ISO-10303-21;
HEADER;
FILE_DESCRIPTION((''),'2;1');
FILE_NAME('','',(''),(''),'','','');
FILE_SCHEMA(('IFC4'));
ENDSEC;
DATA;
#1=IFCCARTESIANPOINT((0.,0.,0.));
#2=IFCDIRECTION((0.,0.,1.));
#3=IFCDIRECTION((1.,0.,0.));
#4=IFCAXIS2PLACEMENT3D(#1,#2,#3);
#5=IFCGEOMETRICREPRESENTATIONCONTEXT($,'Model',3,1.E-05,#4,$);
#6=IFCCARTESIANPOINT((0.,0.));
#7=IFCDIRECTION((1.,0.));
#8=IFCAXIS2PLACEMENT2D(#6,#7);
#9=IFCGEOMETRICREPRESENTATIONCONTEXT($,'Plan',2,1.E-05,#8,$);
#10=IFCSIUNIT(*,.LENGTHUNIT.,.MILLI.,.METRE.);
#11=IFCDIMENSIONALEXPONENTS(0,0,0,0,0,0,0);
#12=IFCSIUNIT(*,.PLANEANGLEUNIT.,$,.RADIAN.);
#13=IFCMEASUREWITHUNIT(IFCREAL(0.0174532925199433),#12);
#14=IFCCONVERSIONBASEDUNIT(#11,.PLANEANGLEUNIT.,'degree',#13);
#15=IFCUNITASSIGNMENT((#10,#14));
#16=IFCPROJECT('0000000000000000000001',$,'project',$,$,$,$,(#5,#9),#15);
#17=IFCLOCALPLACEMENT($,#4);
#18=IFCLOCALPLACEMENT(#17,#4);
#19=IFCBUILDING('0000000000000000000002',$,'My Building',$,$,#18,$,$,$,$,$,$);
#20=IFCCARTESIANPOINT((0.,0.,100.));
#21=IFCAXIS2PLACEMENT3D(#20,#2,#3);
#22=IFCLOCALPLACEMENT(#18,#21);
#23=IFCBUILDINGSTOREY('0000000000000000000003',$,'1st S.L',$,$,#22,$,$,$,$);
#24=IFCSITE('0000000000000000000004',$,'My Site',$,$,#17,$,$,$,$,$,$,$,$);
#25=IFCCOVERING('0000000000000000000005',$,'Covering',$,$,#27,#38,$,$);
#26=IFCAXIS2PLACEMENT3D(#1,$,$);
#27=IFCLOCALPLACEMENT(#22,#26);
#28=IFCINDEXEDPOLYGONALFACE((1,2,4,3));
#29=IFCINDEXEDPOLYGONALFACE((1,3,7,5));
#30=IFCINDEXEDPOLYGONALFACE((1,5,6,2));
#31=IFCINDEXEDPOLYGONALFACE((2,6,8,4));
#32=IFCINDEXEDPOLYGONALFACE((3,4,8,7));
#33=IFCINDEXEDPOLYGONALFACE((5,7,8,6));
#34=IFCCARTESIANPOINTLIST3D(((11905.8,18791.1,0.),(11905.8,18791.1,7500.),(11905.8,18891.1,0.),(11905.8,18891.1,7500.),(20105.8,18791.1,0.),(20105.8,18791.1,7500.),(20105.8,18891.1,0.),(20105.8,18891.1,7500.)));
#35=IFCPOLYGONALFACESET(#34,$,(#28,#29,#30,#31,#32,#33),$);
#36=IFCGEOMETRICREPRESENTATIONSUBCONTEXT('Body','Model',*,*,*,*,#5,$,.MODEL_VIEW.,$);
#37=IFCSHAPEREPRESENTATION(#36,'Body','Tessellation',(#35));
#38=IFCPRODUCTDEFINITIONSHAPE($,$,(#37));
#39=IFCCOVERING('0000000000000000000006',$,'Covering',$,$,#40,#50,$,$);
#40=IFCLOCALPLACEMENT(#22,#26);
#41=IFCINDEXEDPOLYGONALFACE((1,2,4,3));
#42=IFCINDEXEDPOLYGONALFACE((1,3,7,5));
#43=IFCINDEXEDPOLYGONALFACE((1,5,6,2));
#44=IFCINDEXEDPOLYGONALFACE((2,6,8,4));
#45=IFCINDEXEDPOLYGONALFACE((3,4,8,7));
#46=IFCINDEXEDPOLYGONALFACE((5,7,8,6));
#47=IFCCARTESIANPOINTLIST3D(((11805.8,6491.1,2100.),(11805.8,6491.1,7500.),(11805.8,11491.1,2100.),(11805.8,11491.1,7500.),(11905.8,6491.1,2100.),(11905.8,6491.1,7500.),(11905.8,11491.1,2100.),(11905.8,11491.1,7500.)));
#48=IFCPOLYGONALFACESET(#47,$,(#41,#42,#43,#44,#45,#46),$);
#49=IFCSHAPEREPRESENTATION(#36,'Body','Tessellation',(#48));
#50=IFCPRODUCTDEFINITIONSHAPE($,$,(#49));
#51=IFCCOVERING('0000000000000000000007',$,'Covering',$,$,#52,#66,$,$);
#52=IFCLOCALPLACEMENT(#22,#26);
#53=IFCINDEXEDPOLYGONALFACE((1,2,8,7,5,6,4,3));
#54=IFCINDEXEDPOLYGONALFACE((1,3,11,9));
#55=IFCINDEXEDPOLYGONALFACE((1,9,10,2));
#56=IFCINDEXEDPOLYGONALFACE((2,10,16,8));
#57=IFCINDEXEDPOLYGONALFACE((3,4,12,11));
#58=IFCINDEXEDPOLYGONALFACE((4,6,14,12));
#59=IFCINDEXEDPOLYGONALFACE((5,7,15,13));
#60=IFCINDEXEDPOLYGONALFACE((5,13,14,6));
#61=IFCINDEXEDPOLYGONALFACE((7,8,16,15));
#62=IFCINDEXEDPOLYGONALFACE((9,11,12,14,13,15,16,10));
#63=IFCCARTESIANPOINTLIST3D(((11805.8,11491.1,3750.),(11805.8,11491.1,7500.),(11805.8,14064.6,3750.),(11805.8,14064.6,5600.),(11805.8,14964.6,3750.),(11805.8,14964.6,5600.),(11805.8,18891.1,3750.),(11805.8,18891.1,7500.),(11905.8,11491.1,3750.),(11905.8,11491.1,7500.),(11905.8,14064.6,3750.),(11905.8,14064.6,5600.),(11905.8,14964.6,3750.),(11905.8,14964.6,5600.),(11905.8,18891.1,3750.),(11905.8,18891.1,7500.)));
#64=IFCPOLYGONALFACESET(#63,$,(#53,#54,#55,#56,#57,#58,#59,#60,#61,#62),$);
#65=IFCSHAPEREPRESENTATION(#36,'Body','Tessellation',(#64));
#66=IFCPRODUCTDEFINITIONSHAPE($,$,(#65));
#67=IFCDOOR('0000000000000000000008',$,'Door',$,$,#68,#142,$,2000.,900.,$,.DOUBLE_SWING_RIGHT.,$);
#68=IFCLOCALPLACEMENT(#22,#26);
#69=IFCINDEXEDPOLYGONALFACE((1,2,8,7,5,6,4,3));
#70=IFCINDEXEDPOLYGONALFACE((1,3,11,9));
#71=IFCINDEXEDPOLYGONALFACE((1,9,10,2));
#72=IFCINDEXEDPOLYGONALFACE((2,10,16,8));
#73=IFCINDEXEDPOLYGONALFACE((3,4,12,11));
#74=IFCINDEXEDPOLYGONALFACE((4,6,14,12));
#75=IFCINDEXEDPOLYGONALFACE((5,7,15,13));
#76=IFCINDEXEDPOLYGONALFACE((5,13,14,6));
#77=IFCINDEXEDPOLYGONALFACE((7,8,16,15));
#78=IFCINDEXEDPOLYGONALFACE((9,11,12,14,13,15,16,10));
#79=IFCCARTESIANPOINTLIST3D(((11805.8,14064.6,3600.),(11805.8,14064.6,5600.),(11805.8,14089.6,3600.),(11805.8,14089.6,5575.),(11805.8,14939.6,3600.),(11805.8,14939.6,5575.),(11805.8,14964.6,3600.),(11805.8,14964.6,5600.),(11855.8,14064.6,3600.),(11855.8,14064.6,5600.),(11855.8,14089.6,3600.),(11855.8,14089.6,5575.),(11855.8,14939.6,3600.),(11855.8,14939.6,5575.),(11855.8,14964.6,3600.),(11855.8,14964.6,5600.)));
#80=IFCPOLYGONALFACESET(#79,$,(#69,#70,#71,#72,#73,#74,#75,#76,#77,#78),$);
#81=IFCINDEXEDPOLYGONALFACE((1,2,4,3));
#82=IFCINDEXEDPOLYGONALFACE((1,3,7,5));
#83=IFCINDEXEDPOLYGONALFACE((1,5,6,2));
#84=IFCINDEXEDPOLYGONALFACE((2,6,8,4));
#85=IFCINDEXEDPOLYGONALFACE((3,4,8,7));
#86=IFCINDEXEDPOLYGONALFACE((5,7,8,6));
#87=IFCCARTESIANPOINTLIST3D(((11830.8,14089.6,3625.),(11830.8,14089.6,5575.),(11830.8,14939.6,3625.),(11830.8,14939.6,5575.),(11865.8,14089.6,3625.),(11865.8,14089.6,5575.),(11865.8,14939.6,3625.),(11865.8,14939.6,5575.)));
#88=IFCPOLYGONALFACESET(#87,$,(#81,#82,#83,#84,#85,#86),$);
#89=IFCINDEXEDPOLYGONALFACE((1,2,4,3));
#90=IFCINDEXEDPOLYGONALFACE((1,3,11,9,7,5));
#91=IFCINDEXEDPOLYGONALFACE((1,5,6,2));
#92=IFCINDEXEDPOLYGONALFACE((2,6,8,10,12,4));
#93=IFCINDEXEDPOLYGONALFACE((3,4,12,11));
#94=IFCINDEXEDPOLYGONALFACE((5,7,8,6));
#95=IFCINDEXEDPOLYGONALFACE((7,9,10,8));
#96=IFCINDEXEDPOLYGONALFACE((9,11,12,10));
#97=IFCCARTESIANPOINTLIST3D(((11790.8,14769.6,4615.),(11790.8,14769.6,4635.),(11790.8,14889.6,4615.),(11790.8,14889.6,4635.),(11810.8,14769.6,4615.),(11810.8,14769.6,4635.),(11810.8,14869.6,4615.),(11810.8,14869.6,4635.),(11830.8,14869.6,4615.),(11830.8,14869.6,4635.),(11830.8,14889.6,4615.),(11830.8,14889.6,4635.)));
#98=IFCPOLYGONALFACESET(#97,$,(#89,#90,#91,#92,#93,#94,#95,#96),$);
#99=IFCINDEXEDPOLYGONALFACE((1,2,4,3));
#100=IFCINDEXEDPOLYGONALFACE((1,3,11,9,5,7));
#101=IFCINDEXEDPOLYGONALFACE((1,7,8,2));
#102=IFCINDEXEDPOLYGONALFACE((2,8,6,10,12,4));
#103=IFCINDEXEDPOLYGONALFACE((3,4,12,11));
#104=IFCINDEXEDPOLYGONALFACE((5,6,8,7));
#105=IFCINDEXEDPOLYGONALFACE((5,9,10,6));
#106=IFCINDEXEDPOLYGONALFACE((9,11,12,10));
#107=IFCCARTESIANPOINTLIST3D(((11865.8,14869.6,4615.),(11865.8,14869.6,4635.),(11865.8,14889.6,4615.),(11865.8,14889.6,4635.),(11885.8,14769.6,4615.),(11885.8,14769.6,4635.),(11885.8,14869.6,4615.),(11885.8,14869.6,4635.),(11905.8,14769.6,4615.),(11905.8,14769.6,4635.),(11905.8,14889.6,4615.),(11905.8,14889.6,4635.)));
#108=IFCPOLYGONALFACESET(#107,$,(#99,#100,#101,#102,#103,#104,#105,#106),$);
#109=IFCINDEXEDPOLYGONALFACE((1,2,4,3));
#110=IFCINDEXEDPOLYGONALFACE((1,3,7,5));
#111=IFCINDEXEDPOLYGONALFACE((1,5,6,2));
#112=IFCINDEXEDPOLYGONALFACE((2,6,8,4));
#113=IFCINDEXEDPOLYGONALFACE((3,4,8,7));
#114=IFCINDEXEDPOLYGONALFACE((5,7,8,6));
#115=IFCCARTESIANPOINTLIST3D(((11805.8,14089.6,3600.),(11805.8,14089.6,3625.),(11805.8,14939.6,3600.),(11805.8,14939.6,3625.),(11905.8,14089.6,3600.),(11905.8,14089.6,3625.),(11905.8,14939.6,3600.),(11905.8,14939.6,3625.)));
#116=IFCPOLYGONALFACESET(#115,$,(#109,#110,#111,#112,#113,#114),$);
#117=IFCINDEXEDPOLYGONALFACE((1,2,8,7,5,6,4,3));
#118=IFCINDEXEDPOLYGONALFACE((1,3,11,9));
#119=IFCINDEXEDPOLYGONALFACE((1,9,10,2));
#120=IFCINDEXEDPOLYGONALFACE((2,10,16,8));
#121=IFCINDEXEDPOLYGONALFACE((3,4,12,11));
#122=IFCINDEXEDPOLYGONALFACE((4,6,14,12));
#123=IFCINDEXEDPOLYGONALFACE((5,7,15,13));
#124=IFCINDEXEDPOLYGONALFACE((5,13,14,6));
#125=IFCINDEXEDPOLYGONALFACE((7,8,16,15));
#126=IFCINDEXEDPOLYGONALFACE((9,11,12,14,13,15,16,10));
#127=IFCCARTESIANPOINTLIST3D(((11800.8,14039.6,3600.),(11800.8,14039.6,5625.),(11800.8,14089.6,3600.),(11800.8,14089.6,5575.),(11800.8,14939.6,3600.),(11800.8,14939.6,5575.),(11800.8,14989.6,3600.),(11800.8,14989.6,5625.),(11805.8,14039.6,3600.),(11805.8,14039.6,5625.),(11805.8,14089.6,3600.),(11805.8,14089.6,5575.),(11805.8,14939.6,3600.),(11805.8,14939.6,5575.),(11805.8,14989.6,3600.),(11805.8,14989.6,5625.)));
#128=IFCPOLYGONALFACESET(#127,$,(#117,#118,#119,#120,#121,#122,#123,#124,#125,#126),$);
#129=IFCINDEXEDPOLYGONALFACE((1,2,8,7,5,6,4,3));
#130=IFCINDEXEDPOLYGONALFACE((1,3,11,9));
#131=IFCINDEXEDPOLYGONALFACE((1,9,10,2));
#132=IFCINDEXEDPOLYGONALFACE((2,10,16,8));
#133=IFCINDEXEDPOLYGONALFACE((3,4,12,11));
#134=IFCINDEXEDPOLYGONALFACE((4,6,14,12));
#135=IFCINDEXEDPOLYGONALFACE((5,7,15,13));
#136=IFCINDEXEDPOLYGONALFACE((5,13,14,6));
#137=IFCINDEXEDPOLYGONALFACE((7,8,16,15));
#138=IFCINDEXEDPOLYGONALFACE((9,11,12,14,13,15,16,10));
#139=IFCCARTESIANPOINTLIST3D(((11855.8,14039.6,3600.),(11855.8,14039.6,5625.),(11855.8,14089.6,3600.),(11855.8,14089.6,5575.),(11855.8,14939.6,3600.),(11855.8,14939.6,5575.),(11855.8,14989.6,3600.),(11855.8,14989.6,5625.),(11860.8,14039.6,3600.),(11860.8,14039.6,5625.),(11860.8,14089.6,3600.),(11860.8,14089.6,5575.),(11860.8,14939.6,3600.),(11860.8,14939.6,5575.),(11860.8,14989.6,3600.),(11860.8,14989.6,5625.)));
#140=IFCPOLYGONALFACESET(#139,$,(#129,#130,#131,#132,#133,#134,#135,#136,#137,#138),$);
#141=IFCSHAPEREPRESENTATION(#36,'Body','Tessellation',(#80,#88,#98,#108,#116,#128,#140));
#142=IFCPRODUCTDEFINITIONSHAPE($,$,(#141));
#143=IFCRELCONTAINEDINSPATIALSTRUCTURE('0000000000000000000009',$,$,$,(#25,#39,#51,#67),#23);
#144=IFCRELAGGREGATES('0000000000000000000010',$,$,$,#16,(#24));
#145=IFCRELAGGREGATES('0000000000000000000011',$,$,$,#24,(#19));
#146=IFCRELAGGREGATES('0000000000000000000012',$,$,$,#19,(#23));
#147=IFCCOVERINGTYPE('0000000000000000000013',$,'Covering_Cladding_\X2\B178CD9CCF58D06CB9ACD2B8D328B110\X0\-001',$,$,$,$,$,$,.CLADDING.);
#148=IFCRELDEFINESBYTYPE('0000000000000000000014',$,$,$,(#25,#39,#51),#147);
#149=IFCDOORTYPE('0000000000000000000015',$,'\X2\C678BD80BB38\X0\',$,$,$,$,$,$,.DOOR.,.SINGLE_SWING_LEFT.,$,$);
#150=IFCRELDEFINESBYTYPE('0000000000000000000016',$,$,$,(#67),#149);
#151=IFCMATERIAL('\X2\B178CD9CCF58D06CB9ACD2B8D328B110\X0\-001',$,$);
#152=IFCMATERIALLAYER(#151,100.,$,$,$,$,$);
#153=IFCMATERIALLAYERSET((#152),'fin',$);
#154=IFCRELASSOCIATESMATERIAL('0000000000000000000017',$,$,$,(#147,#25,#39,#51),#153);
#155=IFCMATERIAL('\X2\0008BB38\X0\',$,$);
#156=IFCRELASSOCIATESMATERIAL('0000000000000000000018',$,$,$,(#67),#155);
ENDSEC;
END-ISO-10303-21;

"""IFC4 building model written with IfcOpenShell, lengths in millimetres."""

from ifc_helpers import new_model, entity, si_unit, converted_unit, frame, origin_with_axes, origin_2d_with_axis, place, context, subcontext, project, spatial, line, indexed_curve, outline, extrude, shape, source, transform, mapped, material, layer, layer_set, layer_usage, type_object, type_shapes, element, fill, save


model = new_model("IFC4")

# Units and contexts
model_context = context("Model", 3, precision=1e-05, world=origin_with_axes())
plan_context = context("Plan", 2, precision=1e-05, world=origin_2d_with_axis())
body_context_1 = subcontext(model_context, "Body", "Model", "MODEL_VIEW")
body_context_2 = subcontext(plan_context, "Body", "Plan", "PLAN_VIEW")
ifc_project = project(units=[si_unit("LENGTHUNIT", "METRE", prefix="MILLI"), converted_unit("PLANEANGLEUNIT", "degree", entity("IfcReal", 0.0174532925199433), si_unit("PLANEANGLEUNIT", "RADIAN"), dimensions=[0, 0, 0, 0, 0, 0, 0])], contexts=[model_context, plan_context])

# Site, building, storey
site_placement = place(None, origin_with_axes())
site = spatial("IfcSite", under=ifc_project, at=site_placement, Name="My Site")
building_placement = place(site_placement, origin_with_axes())
building = spatial("IfcBuilding", under=site, at=building_placement, Name="My Building")
storey_placement = place(building_placement, frame((0.0, 0.0, 100.0), z_axis=(0.0, 0.0, 1.0), x_axis=(1.0, 0.0, 0.0)))
storey = spatial("IfcBuildingStorey", under=building, at=storey_placement, Name="1st S.L")

# Shared definitions
shared_shape_1 = source(origin_with_axes(), body_context_1, "Body", "SolidModel", [
    extrude(outline(indexed_curve([(0.0, 0.0), (900.0, 0.0), (900.0, 2000.0), (0.0, 2000.0)], segments=[line(1, 2, 3, 4, 1)])), frame((0.0, -600.0, 0.0), z_axis=(0.0, -1.0, 0.0), x_axis=(1.0, 0.0, 0.0)), (0.0, 0.0, -1.0), 1200.0),
])
ifc_material_1 = material(Name="\b문")
door_type_1 = type_object("IfcDoorType", Name="외부문", OperationType="SINGLE_SWING_LEFT", PredefinedType="DOOR")
shared_shape_2 = source(origin_with_axes(), body_context_1, "Body", "SolidModel", [
    extrude(outline(indexed_curve([(0.0, 0.0), (0.0, 2000.0), (900.0, 2000.0), (900.0, 0.0), (875.0, 0.0), (875.0, 1975.0), (25.0, 1975.0), (25.0, 0.0)], segments=[line(1, 2, 3, 4, 5, 6, 7, 8, 1)])), frame((0.0, 0.0, 0.0), z_axis=(0.0, -1.0, 0.0), x_axis=(1.0, 0.0, 0.0)), (0.0, 0.0, -1.0), 50.0),
    extrude(outline(indexed_curve([(0.0, 0.0), (850.0, 0.0), (850.0, 35.0), (0.0, 35.0)], segments=[line(1, 2, 3, 4, 1)])), frame((25.0, 25.0, 25.0), z_axis=(0.0, 0.0, 1.0), x_axis=(1.0, 0.0, 0.0)), (0.0, 0.0, 1.0), 1950.0),
    extrude(outline(indexed_curve([(0.0, 0.0), (0.0, -40.0), (120.0, -40.0), (120.0, -20.0), (20.0, -20.0), (20.0, 0.0)], segments=[line(1, 2, 3, 4, 5, 6, 1)])), frame((75.0, 25.0, 1015.0), z_axis=(0.0, 0.0, 1.0), x_axis=(1.0, 0.0, 0.0)), (0.0, 0.0, 1.0), 20.0),
    extrude(outline(indexed_curve([(0.0, 0.0), (0.0, 40.0), (120.0, 40.0), (120.0, 20.0), (20.0, 20.0), (20.0, 0.0)], segments=[line(1, 2, 3, 4, 5, 6, 1)])), frame((75.0, 60.0, 1015.0), z_axis=(0.0, 0.0, 1.0), x_axis=(1.0, 0.0, 0.0)), (0.0, 0.0, 1.0), 20.0),
    extrude(outline(indexed_curve([(0.0, 0.0), (850.0, 0.0), (850.0, 100.0), (0.0, 100.0)], segments=[line(1, 2, 3, 4, 1)])), frame((25.0, 0.0, 0.0), z_axis=(0.0, 0.0, 1.0), x_axis=(1.0, 0.0, 0.0)), (0.0, 0.0, 1.0), 25.0),
    extrude(outline(indexed_curve([(0.0, 0.0), (0.0, 2025.0), (950.0, 2025.0), (950.0, 0.0), (900.0, 0.0), (900.0, 1975.0), (50.0, 1975.0), (50.0, 0.0)], segments=[line(1, 2, 3, 4, 5, 6, 7, 8, 1)])), frame((-25.0, -5.0, 0.0), z_axis=(0.0, -1.0, 0.0), x_axis=(1.0, 0.0, 0.0)), (0.0, 0.0, -1.0), 5.0),
    extrude(outline(indexed_curve([(0.0, 0.0), (0.0, 2025.0), (950.0, 2025.0), (950.0, 0.0), (900.0, 0.0), (900.0, 1975.0), (50.0, 1975.0), (50.0, 0.0)], segments=[line(1, 2, 3, 4, 5, 6, 7, 8, 1)])), frame((-25.0, 50.0, 0.0), z_axis=(0.0, -1.0, 0.0), x_axis=(1.0, 0.0, 0.0)), (0.0, 0.0, -1.0), 5.0),
])
shared_shape_3 = source(origin_with_axes(), body_context_2, "Body", "Curve2D", [
    entity("IfcIndexedPolyCurve", entity("IfcCartesianPointList2D", [[0.0, 0.0], [25.0, 0.0], [25.0, 50.0], [0.0, 50.0]]), [entity("IfcLineIndex", [1, 2, 3, 4, 1])]),
    entity("IfcIndexedPolyCurve", entity("IfcCartesianPointList2D", [[900.0, 0.0], [875.0, 0.0], [875.0, 50.0], [900.0, 50.0]]), [entity("IfcLineIndex", [1, 2, 3, 4, 1])]),
    entity("IfcIndexedPolyCurve", entity("IfcCartesianPointList2D", [[875.0, 50.0], [875.0, -800.0], [840.0, -800.0]])),
    entity("IfcTrimmedCurve", entity("IfcEllipse", entity("IfcAxis2Placement2D", entity("IfcCartesianPoint", [840.0, 50.0]), entity("IfcDirection", [1.0, 0.0])), 815.0, 850.0), [entity("IfcCartesianPoint", [840.0, 900.0])], [entity("IfcCartesianPoint", [840.0, -800.0])], True, "CARTESIAN"),
    entity("IfcIndexedPolyCurve", entity("IfcCartesianPointList2D", [[875.0, 50.0], [840.0, 50.0], [840.0, 900.0], [875.0, 900.0]]), [entity("IfcLineIndex", [1, 2, 3, 4, 1])]),
])
type_shapes(door_type_1, [shared_shape_2, shared_shape_3])

# Coverings
ifc_material_2 = material(Name="노출콘크리트패널-001")
ifc_layer_1 = layer(ifc_material_2, 100.0)
ifc_layer_set_1 = layer_set([ifc_layer_1], Name="fin")
ifc_layer_usage_1 = layer_usage(ifc_layer_set_1, "AXIS2", "POSITIVE", 0.0)
covering_type = type_object("IfcCoveringType", Name="Covering_Cladding_노출콘크리트패널-001", PredefinedType="CLADDING", material=ifc_layer_set_1)
covering_1_placement = place(storey_placement, frame((11905.8, 18791.1, 0.0), z_axis=(0.0, 0.0, 1.0), x_axis=(1.0, 0.0, 0.0)))
element("IfcCovering", 1, at=covering_1_placement, inside=storey, type_object=covering_type, material=ifc_layer_usage_1, Name="Covering", context=body_context_1, shape_type="SweptSolid", body=[
    extrude(outline(indexed_curve([(0.0, 0.0), (0.0, 100.0), (8200.0, 100.0), (8200.0, 0.0), (0.0, 0.0)], self_intersect=False)), origin_with_axes(), (0.0, 0.0, 1.0), 7500.0),
])
ifc_layer_usage_2 = layer_usage(ifc_layer_set_1, "AXIS2", "POSITIVE", 0.0)
covering_2_placement = place(storey_placement, frame((11805.8, 11491.1, 2100.0), z_axis=(0.0, 0.0, 1.0), x_axis=(-0.000001, -1.0, 0.0)))
element("IfcCovering", 2, at=covering_2_placement, inside=storey, type_object=covering_type, material=ifc_layer_usage_2, Name="Covering", context=body_context_1, shape_type="SweptSolid", body=[
    extrude(outline(indexed_curve([(0.0, 0.0), (0.0, 100.0), (5000.0, 100.0), (5000.0, 0.0), (0.0, 0.0)], self_intersect=False)), origin_with_axes(), (0.0, 0.0, 1.0), 5400.0),
])

# Covering, opening, door
ifc_layer_usage_3 = layer_usage(ifc_layer_set_1, "AXIS2", "POSITIVE", 0.0)
covering_3_placement = place(storey_placement, frame((11805.8, 18891.1, 3750.0), z_axis=(0.0, 0.0, 1.0), x_axis=(-0.000001, -1.0, 0.0)))
covering_3 = element("IfcCovering", 3, at=covering_3_placement, inside=storey, type_object=covering_type, material=ifc_layer_usage_3, Name="Covering", context=body_context_1, shape_type="SweptSolid", body=[
    extrude(outline(indexed_curve([(0.0, 0.0), (0.0, 100.0), (7400.0, 100.0), (7400.0, 0.0), (0.0, 0.0)], self_intersect=False)), origin_with_axes(), (0.0, 0.0, 1.0), 3750.0),
])
opening_1_placement = place(covering_3_placement, frame((3926.4, 0.0, -150.0), z_axis=(0.0, 0.0, 1.0), x_axis=(1.0, 0.0, 0.0)))
opening_1 = element("IfcOpeningElement", 4, at=opening_1_placement, cuts=covering_3, PredefinedType="OPENING", context=body_context_1, shape_type="MappedRepresentation", body=[
    mapped(shared_shape_1, transform((0.0, 0.0, 0.0), x_axis=(1.0, 0.0, 0.0), y_axis=(0.0, 1.0, 0.0), z_axis=(0.0, 0.0, 1.0), scale=1.0)),
])
door_1_placement = place(opening_1_placement, frame((0.0, 0.0, 0.0), z_axis=(0.0, 0.0, 1.0), x_axis=(1.0, 0.0, 0.0)))
door_1 = element("IfcDoor", 5, at=door_1_placement, inside=storey, type_object=door_type_1, material=ifc_material_1, Name="Door", OperationType="DOUBLE_SWING_RIGHT", OverallHeight=2000.0, OverallWidth=900.0, shapes=[
    shape(body_context_1, "Body", "MappedRepresentation", [mapped(shared_shape_2, transform((0.0, 0.0, 0.0), x_axis=(1.0, 0.0, 0.0), y_axis=(0.0, 1.0, 0.0), z_axis=(0.0, 0.0, 1.0), scale=1.0))]),
    shape(body_context_2, "Body", "MappedRepresentation", [mapped(shared_shape_3, transform((0.0, 0.0, 0.0), x_axis=(1.0, 0.0, 0.0), y_axis=(0.0, 1.0, 0.0), z_axis=(0.0, 0.0, 1.0), scale=1.0))]),
])
fill(opening_1, door_1)

save(model, "model.ifc")
